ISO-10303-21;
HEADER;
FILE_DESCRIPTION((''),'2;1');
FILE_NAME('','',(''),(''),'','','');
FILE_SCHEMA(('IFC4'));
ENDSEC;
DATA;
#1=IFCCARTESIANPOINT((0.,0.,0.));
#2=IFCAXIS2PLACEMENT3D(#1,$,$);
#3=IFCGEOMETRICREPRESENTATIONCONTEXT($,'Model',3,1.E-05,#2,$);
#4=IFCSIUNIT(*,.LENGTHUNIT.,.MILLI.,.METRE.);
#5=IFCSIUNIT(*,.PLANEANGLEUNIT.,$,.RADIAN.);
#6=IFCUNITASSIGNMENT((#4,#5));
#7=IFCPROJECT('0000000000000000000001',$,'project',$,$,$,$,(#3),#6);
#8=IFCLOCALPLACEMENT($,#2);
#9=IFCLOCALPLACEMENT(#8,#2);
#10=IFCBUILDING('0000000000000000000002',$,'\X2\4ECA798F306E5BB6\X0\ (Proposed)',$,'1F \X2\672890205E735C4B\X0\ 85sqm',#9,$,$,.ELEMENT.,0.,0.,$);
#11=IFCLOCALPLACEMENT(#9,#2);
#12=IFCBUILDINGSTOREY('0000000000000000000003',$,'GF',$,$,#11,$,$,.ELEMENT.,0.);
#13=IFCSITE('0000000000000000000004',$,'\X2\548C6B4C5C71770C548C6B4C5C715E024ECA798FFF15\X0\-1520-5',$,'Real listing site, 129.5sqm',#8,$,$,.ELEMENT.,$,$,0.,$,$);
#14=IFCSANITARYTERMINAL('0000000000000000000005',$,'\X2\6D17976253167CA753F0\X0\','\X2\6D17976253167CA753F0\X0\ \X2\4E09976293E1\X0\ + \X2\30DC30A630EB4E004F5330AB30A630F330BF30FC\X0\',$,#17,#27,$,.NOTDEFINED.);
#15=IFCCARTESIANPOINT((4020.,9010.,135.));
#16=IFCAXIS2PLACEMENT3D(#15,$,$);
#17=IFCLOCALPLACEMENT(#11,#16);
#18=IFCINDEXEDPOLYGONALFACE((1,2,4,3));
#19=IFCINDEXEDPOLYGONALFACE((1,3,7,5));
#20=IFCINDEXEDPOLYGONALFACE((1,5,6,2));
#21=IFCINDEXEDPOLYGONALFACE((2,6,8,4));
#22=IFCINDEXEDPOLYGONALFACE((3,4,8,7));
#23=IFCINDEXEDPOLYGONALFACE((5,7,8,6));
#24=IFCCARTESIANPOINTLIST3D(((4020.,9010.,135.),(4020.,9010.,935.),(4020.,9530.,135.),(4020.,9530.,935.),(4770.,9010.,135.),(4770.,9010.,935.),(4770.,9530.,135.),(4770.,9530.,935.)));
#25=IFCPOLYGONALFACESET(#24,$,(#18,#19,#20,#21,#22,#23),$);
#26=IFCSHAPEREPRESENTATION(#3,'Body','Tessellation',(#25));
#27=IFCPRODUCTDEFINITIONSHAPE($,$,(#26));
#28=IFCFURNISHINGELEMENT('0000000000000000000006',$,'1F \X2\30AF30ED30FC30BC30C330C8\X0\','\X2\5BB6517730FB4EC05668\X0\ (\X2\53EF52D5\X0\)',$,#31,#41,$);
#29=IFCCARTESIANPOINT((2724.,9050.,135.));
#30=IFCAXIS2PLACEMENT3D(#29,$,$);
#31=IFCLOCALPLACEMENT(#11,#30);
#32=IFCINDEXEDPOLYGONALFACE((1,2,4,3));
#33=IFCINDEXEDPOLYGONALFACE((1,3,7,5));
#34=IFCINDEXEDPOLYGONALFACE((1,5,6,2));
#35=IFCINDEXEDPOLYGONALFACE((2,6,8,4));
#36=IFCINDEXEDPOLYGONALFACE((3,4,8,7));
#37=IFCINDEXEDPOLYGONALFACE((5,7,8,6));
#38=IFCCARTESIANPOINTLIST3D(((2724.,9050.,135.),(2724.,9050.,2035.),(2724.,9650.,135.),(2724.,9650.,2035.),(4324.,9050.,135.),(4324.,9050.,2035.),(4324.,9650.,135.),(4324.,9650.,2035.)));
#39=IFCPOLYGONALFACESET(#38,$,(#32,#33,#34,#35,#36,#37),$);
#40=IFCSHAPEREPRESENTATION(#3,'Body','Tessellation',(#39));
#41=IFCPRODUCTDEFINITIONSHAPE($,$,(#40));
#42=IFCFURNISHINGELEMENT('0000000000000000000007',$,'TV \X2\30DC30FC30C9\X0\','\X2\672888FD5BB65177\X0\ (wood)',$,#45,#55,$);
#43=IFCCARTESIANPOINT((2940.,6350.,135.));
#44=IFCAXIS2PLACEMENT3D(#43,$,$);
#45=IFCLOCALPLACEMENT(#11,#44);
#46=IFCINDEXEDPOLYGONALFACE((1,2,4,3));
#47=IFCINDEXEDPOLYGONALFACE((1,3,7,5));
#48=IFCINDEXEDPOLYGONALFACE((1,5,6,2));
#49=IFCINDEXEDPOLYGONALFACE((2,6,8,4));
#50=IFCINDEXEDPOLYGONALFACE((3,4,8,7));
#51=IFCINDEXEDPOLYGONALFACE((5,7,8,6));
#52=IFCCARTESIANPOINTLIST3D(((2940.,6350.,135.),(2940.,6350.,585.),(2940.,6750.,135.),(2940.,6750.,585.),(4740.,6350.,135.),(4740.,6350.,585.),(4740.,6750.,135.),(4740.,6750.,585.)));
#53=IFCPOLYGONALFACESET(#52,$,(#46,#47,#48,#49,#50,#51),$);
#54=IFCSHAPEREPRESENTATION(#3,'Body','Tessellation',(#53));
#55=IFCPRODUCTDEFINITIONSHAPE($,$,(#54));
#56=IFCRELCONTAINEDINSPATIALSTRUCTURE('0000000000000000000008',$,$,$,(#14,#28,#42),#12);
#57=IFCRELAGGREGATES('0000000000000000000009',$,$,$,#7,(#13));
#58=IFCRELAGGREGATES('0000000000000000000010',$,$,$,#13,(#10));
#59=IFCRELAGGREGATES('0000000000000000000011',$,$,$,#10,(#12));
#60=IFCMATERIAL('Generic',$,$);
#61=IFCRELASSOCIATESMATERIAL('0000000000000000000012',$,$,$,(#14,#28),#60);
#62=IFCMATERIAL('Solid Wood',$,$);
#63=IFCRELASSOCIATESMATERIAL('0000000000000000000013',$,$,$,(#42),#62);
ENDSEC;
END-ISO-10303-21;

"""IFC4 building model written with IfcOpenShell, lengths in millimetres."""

from ifc_helpers import new_model, si_unit, frame, frame_2d, origin, place, context, project, spatial, rectangle, extrude, material, element, save


model = new_model("IFC4")

# Units and contexts
model_context = context("Model", 3, precision=1e-05, world=origin())
ifc_project = project(units=[si_unit("LENGTHUNIT", "METRE", prefix="MILLI"), si_unit("PLANEANGLEUNIT", "RADIAN")], contexts=[model_context])

# Site, building, storey
site_placement = place(None, origin())
site = spatial("IfcSite", under=ifc_project, at=site_placement, Name="和歌山県和歌山市今福５-1520-5", ObjectType="Real listing site, 129.5sqm", CompositionType="ELEMENT", RefElevation=0.0)
building_placement = place(site_placement, origin())
building = spatial("IfcBuilding", under=site, at=building_placement, Name="今福の家 (Proposed)", ObjectType="1F 木造平屋 85sqm", CompositionType="ELEMENT", ElevationOfRefHeight=0.0, ElevationOfTerrain=0.0)
storey_placement = place(building_placement, origin())
storey = spatial("IfcBuildingStorey", under=building, at=storey_placement, Name="GF", CompositionType="ELEMENT", Elevation=0.0)

# Shared definitions
ifc_material_1 = material(Name="Solid Wood")

# Shared definitions
ifc_material_2 = material(Name="Generic")

# Sanitary terminal
sanitary_terminal_1_placement = place(storey_placement, frame((4020.0, 9010.0, 135.0)))
element("IfcSanitaryTerminal", 1, at=sanitary_terminal_1_placement, inside=storey, material=ifc_material_2, Name="洗面化粧台", Description="洗面化粧台 三面鏡 + ボウル一体カウンター", PredefinedType="NOTDEFINED", context=model_context, shape_type="SweptSolid", body=[
    extrude(rectangle(XDim=750.0, YDim=520.0, at=frame_2d((375.0, 260.0))), frame((4020.0, 9010.0, 135.0)), (0.0, 0.0, 1.0), 800.0),
])

# Furnishing elements
furnishing_1_placement = place(storey_placement, frame((2724.0, 9050.0, 135.0)))
element("IfcFurnishingElement", 2, at=furnishing_1_placement, inside=storey, material=ifc_material_2, Name="1F クローゼット", Description="家具・什器 (可動)", context=model_context, shape_type="SweptSolid", body=[
    extrude(rectangle(XDim=1600.0, YDim=600.0, at=frame_2d((800.0, 300.0))), frame((2724.0, 9050.0, 135.0)), (0.0, 0.0, 1.0), 1900.0),
])
furnishing_2_placement = place(storey_placement, frame((2940.0, 6350.0, 135.0)))
element("IfcFurnishingElement", 3, at=furnishing_2_placement, inside=storey, material=ifc_material_1, Name="TV ボード", Description="木製家具 (wood)", context=model_context, shape_type="SweptSolid", body=[
    extrude(rectangle(XDim=1800.0, YDim=400.0, at=frame_2d((900.0, 200.0))), frame((2940.0, 6350.0, 135.0)), (0.0, 0.0, 1.0), 450.0),
])

save(model, "model.ifc")
